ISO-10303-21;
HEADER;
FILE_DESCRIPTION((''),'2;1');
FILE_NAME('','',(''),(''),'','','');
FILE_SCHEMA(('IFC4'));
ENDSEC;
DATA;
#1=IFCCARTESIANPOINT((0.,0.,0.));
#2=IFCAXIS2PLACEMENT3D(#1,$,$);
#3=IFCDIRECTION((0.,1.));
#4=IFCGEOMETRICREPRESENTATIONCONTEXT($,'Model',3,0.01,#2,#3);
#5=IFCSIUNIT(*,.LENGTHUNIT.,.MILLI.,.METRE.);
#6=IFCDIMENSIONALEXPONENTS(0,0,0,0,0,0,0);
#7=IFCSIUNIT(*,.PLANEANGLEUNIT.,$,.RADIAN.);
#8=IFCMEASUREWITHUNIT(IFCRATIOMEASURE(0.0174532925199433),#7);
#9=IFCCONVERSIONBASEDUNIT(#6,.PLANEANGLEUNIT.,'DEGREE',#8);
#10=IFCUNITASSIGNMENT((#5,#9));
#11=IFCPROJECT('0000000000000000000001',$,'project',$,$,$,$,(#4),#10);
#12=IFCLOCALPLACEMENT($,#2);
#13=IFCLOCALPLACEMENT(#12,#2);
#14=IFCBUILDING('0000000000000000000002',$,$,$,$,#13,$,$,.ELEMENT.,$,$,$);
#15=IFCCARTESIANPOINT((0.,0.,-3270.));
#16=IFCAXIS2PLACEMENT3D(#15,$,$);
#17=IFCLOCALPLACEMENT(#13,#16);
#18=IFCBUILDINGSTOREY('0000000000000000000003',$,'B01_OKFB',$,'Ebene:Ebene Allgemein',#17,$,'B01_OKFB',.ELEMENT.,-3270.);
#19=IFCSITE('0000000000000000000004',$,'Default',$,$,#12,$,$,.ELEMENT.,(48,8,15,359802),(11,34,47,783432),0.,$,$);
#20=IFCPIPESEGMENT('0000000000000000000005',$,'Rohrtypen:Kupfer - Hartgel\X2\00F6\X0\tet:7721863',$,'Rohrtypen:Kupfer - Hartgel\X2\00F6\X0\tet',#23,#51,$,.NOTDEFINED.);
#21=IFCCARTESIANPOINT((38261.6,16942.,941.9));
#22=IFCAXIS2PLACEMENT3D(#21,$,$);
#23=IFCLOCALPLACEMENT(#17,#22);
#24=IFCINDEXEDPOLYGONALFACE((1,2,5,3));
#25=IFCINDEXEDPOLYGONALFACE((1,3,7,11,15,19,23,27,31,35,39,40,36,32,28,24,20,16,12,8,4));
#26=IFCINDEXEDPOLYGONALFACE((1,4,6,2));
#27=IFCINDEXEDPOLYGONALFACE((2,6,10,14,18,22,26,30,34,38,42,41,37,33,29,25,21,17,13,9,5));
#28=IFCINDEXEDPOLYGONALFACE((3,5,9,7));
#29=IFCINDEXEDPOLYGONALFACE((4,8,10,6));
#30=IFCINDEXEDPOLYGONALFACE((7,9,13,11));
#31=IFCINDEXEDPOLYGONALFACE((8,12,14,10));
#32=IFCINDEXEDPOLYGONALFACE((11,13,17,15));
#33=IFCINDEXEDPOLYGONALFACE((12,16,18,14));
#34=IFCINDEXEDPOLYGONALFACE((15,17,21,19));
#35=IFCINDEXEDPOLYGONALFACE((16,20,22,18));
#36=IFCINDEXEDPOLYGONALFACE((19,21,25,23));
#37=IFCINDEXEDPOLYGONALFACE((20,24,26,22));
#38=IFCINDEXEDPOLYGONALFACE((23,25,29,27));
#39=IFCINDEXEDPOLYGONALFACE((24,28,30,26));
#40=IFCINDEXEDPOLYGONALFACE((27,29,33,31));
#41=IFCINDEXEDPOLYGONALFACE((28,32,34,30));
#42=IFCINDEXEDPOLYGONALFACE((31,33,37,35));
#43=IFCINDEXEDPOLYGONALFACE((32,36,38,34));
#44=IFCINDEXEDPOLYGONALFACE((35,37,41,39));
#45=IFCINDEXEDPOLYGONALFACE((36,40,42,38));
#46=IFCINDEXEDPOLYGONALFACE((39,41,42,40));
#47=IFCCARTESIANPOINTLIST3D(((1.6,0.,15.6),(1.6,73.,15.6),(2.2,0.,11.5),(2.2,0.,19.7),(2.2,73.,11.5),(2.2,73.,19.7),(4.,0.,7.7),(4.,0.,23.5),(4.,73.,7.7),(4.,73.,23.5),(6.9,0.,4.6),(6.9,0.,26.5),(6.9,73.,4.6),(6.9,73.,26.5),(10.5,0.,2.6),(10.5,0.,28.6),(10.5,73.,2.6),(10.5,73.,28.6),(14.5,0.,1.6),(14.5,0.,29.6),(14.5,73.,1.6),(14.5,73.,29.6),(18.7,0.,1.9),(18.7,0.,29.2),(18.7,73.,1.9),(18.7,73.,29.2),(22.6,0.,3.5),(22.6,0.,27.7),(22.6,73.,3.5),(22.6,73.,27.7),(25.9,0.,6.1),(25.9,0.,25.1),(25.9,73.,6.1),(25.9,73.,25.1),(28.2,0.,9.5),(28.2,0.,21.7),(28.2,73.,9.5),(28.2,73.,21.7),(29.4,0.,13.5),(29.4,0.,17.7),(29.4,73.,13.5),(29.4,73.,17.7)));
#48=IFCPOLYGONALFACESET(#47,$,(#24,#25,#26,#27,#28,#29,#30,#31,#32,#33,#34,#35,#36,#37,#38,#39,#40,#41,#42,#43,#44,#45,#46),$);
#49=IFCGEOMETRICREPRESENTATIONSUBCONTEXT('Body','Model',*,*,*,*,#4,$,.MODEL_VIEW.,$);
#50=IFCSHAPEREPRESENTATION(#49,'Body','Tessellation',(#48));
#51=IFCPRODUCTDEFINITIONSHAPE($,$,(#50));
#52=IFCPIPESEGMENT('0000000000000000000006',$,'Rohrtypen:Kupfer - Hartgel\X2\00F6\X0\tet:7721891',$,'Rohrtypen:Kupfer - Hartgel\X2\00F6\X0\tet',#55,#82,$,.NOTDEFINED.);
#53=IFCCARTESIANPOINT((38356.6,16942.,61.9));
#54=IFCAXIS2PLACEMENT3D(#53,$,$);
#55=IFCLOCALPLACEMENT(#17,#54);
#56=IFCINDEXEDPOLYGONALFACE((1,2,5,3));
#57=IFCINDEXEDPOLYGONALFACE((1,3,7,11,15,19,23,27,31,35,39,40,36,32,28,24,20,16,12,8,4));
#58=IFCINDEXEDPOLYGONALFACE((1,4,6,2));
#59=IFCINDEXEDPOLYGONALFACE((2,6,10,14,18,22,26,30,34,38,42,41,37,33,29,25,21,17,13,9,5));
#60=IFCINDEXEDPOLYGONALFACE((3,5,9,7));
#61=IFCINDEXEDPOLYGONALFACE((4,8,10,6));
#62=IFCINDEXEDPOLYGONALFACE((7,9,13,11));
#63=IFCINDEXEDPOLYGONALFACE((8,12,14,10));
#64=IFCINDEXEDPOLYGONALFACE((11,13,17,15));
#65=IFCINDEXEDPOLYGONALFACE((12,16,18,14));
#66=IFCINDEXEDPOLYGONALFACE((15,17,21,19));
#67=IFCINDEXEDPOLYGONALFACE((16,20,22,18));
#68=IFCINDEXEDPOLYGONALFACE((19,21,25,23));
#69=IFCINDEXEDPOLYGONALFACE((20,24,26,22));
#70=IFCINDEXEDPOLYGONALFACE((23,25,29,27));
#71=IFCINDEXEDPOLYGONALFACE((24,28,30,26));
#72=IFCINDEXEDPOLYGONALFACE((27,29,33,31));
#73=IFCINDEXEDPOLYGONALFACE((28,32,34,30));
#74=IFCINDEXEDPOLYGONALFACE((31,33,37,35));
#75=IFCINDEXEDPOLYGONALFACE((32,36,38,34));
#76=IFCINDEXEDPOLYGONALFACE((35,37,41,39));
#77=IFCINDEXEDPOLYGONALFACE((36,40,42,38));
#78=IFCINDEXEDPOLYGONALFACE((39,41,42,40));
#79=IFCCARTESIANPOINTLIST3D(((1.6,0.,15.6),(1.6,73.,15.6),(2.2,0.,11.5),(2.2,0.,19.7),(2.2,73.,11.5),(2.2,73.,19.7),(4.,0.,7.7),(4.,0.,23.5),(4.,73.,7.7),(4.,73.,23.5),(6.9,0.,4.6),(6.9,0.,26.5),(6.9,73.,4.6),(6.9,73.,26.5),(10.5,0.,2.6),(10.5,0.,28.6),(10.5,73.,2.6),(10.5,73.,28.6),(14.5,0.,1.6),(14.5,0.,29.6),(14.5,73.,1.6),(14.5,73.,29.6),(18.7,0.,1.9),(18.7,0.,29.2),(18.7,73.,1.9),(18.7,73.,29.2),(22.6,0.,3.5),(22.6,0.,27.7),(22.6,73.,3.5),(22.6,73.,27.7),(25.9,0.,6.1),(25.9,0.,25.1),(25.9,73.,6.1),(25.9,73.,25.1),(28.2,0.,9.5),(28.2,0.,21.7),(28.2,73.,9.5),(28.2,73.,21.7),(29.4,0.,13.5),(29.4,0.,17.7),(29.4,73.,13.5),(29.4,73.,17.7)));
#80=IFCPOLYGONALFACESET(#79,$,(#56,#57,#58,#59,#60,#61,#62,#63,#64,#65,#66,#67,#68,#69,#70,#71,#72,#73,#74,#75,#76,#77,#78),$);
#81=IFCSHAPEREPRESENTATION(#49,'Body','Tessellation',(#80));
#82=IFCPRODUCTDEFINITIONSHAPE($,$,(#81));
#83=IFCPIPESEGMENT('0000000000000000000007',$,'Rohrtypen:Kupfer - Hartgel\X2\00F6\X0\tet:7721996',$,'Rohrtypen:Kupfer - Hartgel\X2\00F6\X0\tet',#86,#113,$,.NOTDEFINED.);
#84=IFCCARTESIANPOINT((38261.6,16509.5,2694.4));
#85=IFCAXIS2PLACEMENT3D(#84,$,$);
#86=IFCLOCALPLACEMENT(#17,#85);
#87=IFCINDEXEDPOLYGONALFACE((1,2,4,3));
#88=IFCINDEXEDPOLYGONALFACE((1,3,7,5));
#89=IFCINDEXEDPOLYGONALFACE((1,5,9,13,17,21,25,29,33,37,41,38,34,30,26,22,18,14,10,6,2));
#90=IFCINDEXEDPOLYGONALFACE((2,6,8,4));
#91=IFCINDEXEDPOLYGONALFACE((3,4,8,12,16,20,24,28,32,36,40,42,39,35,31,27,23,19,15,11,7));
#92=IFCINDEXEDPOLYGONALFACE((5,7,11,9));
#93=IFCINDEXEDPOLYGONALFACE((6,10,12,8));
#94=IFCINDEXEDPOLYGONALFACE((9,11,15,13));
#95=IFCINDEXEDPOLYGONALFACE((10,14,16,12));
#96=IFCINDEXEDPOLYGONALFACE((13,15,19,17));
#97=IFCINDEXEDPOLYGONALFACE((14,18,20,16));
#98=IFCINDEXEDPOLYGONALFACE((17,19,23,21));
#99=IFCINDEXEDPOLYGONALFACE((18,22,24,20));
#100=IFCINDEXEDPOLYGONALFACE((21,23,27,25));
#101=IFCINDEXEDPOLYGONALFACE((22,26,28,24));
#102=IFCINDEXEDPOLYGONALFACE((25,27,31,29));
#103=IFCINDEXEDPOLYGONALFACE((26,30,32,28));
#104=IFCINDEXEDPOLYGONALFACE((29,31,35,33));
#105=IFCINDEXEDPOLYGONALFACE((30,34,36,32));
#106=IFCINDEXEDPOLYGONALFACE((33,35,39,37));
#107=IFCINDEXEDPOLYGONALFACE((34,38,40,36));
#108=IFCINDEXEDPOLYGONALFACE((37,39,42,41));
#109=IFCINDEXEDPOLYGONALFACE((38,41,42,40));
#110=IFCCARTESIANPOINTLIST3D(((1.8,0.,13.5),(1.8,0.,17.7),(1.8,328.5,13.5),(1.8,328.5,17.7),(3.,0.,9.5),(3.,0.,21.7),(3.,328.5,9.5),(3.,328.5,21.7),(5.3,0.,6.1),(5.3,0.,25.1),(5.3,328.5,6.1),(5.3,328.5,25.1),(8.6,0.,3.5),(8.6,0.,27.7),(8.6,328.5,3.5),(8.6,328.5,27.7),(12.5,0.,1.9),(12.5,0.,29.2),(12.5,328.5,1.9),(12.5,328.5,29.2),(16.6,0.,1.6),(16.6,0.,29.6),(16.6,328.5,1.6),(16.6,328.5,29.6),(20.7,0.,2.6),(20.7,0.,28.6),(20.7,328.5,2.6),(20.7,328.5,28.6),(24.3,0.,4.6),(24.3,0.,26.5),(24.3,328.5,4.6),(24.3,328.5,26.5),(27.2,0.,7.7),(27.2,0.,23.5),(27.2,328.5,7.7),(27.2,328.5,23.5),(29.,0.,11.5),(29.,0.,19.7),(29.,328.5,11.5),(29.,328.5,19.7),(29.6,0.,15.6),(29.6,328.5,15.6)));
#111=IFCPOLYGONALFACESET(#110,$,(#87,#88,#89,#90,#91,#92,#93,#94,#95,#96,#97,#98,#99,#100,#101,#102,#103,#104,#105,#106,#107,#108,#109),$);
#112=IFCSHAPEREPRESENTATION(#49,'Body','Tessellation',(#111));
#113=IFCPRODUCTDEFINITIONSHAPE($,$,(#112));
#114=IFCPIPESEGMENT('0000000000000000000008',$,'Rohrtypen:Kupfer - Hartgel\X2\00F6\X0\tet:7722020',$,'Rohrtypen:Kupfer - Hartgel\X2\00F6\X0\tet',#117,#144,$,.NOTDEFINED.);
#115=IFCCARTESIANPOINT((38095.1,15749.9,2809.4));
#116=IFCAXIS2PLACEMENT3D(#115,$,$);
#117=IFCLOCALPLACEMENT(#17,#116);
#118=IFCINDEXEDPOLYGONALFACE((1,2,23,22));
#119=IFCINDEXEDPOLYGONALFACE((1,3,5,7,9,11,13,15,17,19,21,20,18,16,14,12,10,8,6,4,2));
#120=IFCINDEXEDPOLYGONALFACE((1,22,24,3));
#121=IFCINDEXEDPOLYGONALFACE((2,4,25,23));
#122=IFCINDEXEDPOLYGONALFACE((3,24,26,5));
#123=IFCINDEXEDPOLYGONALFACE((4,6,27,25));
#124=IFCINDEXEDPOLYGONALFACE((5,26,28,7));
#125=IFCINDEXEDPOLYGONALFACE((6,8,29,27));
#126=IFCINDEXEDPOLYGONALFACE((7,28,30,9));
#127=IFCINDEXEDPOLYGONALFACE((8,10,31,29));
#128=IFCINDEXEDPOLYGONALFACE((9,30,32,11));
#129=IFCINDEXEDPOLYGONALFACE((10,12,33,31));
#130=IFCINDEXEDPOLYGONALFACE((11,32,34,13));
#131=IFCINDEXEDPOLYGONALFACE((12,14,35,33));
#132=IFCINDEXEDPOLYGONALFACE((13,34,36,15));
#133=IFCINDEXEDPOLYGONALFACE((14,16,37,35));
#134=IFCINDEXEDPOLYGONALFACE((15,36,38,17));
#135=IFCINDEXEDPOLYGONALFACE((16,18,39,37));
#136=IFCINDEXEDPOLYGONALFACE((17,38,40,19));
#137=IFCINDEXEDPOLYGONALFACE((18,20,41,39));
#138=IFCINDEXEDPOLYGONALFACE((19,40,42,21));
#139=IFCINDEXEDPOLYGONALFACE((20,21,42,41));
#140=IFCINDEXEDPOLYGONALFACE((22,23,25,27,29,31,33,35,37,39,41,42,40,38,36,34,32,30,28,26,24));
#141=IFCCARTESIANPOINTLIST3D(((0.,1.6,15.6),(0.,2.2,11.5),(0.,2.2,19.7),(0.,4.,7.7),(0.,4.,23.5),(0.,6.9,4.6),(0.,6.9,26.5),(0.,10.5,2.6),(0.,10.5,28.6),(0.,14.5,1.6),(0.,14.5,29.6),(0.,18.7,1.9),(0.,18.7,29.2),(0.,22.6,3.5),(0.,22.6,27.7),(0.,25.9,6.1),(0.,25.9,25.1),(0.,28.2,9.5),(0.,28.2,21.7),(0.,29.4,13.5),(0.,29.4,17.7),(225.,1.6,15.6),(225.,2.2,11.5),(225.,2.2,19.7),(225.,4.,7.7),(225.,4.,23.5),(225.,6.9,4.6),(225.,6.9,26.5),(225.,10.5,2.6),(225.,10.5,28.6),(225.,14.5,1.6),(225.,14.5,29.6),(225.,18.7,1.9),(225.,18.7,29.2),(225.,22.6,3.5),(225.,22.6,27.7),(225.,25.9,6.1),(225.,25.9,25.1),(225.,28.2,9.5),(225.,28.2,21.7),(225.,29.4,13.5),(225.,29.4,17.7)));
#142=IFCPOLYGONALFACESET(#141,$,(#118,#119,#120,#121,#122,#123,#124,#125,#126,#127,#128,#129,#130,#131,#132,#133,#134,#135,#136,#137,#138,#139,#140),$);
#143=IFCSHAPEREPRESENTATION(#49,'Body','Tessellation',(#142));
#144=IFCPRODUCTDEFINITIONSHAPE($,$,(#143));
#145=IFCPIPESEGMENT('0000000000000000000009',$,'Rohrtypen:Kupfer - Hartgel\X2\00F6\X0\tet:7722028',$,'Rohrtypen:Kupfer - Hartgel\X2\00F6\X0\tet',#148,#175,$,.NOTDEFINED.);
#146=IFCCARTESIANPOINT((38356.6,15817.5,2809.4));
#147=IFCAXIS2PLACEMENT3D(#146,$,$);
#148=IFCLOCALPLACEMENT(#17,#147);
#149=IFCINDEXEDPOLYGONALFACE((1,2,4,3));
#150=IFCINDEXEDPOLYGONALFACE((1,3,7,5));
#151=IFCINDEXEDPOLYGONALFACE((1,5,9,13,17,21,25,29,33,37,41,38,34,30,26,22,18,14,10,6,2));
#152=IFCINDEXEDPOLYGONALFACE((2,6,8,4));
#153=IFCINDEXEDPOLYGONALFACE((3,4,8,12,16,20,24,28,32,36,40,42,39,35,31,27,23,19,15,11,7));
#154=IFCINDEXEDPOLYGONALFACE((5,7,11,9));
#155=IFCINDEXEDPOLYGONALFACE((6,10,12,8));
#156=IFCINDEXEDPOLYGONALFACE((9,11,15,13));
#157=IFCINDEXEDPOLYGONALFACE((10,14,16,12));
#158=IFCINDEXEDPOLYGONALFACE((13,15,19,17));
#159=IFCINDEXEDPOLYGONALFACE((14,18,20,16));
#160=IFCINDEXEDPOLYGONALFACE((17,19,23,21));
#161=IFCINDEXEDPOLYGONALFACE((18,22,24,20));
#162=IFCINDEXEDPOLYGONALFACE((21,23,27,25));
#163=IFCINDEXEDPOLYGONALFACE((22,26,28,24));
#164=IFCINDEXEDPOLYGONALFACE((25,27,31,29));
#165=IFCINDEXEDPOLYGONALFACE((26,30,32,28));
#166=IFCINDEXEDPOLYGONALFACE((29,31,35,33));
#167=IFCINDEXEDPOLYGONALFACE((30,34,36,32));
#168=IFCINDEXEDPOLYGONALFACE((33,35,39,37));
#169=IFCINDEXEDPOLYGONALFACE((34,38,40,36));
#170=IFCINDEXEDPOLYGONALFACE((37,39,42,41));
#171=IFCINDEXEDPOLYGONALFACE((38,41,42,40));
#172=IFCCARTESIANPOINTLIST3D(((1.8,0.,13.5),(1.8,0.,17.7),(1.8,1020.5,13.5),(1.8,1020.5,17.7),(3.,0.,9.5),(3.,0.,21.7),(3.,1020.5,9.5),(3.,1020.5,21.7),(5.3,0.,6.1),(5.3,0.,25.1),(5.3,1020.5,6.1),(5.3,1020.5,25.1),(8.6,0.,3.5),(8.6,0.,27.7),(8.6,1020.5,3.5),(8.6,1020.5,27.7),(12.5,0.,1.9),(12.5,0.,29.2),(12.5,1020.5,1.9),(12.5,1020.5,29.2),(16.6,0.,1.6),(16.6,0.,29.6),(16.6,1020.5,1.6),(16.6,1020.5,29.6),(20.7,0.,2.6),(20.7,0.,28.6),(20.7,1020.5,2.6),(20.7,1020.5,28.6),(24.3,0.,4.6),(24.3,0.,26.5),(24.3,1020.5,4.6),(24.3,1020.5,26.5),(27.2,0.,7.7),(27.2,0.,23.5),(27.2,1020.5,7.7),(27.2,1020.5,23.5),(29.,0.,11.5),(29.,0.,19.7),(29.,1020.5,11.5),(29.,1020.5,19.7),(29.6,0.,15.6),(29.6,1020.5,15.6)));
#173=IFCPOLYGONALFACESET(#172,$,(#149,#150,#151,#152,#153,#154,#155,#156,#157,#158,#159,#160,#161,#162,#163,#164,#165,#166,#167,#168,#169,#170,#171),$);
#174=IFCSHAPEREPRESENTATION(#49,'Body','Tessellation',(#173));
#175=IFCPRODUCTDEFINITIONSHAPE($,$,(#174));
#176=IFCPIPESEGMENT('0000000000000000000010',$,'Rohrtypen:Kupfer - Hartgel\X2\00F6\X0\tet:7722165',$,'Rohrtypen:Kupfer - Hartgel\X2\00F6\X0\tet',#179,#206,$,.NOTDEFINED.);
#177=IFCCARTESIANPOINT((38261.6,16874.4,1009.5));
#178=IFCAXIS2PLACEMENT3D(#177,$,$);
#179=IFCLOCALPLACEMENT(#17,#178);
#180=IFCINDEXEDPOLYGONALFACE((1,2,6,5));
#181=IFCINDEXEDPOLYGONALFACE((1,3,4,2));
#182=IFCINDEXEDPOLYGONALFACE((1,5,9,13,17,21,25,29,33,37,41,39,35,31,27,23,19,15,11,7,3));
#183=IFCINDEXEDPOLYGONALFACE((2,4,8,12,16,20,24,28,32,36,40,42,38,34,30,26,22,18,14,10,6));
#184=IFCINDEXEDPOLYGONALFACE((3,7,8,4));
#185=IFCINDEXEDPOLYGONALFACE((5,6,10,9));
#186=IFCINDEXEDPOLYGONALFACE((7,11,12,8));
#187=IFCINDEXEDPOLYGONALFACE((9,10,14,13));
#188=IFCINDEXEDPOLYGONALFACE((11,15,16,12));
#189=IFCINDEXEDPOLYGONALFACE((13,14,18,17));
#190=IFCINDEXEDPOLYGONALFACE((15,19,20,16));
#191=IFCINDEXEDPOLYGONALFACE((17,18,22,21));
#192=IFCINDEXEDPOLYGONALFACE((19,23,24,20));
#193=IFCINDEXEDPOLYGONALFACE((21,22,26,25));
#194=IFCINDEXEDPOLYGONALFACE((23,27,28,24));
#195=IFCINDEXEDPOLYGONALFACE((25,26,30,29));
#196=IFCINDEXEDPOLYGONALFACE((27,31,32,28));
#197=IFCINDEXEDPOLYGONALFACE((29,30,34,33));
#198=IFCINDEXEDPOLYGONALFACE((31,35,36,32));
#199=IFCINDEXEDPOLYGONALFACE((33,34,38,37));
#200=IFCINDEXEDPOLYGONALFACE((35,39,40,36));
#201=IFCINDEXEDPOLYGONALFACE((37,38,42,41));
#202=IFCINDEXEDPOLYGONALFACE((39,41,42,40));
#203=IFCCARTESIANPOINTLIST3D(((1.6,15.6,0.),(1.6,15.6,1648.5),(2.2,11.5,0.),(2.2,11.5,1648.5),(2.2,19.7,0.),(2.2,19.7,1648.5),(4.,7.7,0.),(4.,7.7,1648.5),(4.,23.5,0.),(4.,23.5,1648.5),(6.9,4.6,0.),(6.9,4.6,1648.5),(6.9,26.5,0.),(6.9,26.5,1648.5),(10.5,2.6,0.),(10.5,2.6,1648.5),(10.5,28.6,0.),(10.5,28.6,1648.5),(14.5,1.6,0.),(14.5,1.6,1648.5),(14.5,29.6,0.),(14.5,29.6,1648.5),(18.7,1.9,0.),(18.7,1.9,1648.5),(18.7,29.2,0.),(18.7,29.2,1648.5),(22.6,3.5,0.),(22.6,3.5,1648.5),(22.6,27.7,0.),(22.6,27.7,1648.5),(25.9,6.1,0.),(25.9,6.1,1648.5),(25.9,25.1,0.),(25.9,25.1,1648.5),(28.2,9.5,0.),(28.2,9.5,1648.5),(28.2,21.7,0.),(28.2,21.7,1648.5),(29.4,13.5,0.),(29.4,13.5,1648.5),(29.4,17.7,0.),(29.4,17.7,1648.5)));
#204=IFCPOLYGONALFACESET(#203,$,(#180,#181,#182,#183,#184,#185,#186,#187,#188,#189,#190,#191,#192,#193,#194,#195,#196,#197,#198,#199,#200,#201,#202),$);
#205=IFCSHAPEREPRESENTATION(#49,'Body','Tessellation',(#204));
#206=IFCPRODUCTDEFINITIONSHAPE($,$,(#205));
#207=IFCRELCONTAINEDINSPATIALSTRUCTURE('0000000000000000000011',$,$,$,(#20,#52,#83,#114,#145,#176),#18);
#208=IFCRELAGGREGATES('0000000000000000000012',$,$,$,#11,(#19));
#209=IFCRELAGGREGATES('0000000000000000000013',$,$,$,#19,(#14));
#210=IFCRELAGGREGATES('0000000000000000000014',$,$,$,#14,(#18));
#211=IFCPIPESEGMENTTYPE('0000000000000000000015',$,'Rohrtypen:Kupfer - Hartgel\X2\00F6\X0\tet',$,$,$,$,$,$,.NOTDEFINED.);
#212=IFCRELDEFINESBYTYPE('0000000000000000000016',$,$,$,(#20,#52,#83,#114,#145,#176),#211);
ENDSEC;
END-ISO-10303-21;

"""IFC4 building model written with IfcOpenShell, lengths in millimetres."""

from ifc_helpers import new_model, entity, si_unit, converted_unit, direction, frame, frame_2d, origin, origin_2d_with_axis, place, context, subcontext, project, spatial, circle, extrude, type_object, element, save


model = new_model("IFC4")

# Units and contexts
model_context = context("Model", 3, precision=0.01, world=origin(), true_north=direction((0.0, 1.0)))
body_context = subcontext(model_context, "Body", "Model", "MODEL_VIEW")
ifc_project = project(units=[si_unit("LENGTHUNIT", "METRE", prefix="MILLI"), converted_unit("PLANEANGLEUNIT", "DEGREE", entity("IfcRatioMeasure", 0.0174532925199433), si_unit("PLANEANGLEUNIT", "RADIAN"), dimensions=[0, 0, 0, 0, 0, 0, 0])], contexts=[model_context])

# Site, building, storey
site_placement = place(None, origin())
site = spatial("IfcSite", under=ifc_project, at=site_placement, Name="Default", CompositionType="ELEMENT", RefLatitude=(48, 8, 15, 359802), RefLongitude=(11, 34, 47, 783432), RefElevation=0.0)
building_placement = place(site_placement, origin())
building = spatial("IfcBuilding", under=site, at=building_placement, CompositionType="ELEMENT")
storey_placement = place(building_placement, frame((0.0, 0.0, -3270.0)))
storey = spatial("IfcBuildingStorey", under=building, at=storey_placement, Name="B01_OKFB", ObjectType="Ebene:Ebene Allgemein", LongName="B01_OKFB", CompositionType="ELEMENT", Elevation=-3270.0)

# Pipe segments
pipe_segment_type = type_object("IfcPipeSegmentType", Name="Rohrtypen:Kupfer - Hartgelötet", PredefinedType="NOTDEFINED")
pipe_segment_1_placement = place(storey_placement, frame((38261.6, 16942.0, 941.9)))
element("IfcPipeSegment", 1, at=pipe_segment_1_placement, inside=storey, type_object=pipe_segment_type, Name="Rohrtypen:Kupfer - Hartgelötet:7721863", ObjectType="Rohrtypen:Kupfer - Hartgelötet", PredefinedType="NOTDEFINED", context=body_context, shape_type="SweptSolid", body=[
    extrude(circle(Radius=14.0, at=origin_2d_with_axis()), frame((15.6, 0.0, 15.6), z_axis=(0.0, 1.0, 0.0), x_axis=(-1.0, 0.0, 0.0)), (0.0, 0.0, 1.0), 73.0),
])
pipe_segment_2_placement = place(storey_placement, frame((38356.6, 16942.0, 61.9)))
element("IfcPipeSegment", 2, at=pipe_segment_2_placement, inside=storey, type_object=pipe_segment_type, Name="Rohrtypen:Kupfer - Hartgelötet:7721891", ObjectType="Rohrtypen:Kupfer - Hartgelötet", PredefinedType="NOTDEFINED", context=body_context, shape_type="SweptSolid", body=[
    extrude(circle(Radius=14.0, at=frame_2d((0.0, 0.0), x_axis=(1.0, 0.0))), frame((15.6, 0.0, 15.6), z_axis=(0.0, 1.0, 0.0), x_axis=(-1.0, 0.0, 0.0)), (0.0, 0.0, 1.0), 73.0),
])
pipe_segment_3_placement = place(storey_placement, frame((38261.6, 16509.5, 2694.4)))
element("IfcPipeSegment", 3, at=pipe_segment_3_placement, inside=storey, type_object=pipe_segment_type, Name="Rohrtypen:Kupfer - Hartgelötet:7721996", ObjectType="Rohrtypen:Kupfer - Hartgelötet", PredefinedType="NOTDEFINED", context=body_context, shape_type="SweptSolid", body=[
    extrude(circle(Radius=14.0, at=origin_2d_with_axis()), frame((15.6, 0.0, 15.6), z_axis=(0.0, 1.0, 0.0), x_axis=(1.0, 0.0, 0.0)), (0.0, 0.0, 1.0), 328.5),
])
pipe_segment_4_placement = place(storey_placement, frame((38095.1, 15749.9, 2809.4)))
element("IfcPipeSegment", 4, at=pipe_segment_4_placement, inside=storey, type_object=pipe_segment_type, Name="Rohrtypen:Kupfer - Hartgelötet:7722020", ObjectType="Rohrtypen:Kupfer - Hartgelötet", PredefinedType="NOTDEFINED", context=body_context, shape_type="SweptSolid", body=[
    extrude(circle(Radius=14.0, at=origin_2d_with_axis()), frame((0.0, 15.6, 15.6), z_axis=(1.0, 0.0, 0.0), x_axis=(0.0, -1.0, 0.0)), (0.0, 0.0, 1.0), 225.0),
])
pipe_segment_5_placement = place(storey_placement, frame((38356.6, 15817.5, 2809.4)))
element("IfcPipeSegment", 5, at=pipe_segment_5_placement, inside=storey, type_object=pipe_segment_type, Name="Rohrtypen:Kupfer - Hartgelötet:7722028", ObjectType="Rohrtypen:Kupfer - Hartgelötet", PredefinedType="NOTDEFINED", context=body_context, shape_type="SweptSolid", body=[
    extrude(circle(Radius=14.0, at=origin_2d_with_axis()), frame((15.6, 0.0, 15.6), z_axis=(0.0, 1.0, 0.0), x_axis=(1.0, 0.0, 0.0)), (0.0, 0.0, 1.0), 1020.5),
])
pipe_segment_6_placement = place(storey_placement, frame((38261.6, 16874.4, 1009.5)))
element("IfcPipeSegment", 6, at=pipe_segment_6_placement, inside=storey, type_object=pipe_segment_type, Name="Rohrtypen:Kupfer - Hartgelötet:7722165", ObjectType="Rohrtypen:Kupfer - Hartgelötet", PredefinedType="NOTDEFINED", context=body_context, shape_type="SweptSolid", body=[
    extrude(circle(Radius=14.0, at=frame_2d((0.0, 0.0), x_axis=(1.0, 0.0))), frame((15.6, 15.6, 0.0), z_axis=(0.0, 0.0, 1.0), x_axis=(-1.0, 0.0, 0.0)), (0.0, 0.0, 1.0), 1648.5),
])

save(model, "model.ifc")
